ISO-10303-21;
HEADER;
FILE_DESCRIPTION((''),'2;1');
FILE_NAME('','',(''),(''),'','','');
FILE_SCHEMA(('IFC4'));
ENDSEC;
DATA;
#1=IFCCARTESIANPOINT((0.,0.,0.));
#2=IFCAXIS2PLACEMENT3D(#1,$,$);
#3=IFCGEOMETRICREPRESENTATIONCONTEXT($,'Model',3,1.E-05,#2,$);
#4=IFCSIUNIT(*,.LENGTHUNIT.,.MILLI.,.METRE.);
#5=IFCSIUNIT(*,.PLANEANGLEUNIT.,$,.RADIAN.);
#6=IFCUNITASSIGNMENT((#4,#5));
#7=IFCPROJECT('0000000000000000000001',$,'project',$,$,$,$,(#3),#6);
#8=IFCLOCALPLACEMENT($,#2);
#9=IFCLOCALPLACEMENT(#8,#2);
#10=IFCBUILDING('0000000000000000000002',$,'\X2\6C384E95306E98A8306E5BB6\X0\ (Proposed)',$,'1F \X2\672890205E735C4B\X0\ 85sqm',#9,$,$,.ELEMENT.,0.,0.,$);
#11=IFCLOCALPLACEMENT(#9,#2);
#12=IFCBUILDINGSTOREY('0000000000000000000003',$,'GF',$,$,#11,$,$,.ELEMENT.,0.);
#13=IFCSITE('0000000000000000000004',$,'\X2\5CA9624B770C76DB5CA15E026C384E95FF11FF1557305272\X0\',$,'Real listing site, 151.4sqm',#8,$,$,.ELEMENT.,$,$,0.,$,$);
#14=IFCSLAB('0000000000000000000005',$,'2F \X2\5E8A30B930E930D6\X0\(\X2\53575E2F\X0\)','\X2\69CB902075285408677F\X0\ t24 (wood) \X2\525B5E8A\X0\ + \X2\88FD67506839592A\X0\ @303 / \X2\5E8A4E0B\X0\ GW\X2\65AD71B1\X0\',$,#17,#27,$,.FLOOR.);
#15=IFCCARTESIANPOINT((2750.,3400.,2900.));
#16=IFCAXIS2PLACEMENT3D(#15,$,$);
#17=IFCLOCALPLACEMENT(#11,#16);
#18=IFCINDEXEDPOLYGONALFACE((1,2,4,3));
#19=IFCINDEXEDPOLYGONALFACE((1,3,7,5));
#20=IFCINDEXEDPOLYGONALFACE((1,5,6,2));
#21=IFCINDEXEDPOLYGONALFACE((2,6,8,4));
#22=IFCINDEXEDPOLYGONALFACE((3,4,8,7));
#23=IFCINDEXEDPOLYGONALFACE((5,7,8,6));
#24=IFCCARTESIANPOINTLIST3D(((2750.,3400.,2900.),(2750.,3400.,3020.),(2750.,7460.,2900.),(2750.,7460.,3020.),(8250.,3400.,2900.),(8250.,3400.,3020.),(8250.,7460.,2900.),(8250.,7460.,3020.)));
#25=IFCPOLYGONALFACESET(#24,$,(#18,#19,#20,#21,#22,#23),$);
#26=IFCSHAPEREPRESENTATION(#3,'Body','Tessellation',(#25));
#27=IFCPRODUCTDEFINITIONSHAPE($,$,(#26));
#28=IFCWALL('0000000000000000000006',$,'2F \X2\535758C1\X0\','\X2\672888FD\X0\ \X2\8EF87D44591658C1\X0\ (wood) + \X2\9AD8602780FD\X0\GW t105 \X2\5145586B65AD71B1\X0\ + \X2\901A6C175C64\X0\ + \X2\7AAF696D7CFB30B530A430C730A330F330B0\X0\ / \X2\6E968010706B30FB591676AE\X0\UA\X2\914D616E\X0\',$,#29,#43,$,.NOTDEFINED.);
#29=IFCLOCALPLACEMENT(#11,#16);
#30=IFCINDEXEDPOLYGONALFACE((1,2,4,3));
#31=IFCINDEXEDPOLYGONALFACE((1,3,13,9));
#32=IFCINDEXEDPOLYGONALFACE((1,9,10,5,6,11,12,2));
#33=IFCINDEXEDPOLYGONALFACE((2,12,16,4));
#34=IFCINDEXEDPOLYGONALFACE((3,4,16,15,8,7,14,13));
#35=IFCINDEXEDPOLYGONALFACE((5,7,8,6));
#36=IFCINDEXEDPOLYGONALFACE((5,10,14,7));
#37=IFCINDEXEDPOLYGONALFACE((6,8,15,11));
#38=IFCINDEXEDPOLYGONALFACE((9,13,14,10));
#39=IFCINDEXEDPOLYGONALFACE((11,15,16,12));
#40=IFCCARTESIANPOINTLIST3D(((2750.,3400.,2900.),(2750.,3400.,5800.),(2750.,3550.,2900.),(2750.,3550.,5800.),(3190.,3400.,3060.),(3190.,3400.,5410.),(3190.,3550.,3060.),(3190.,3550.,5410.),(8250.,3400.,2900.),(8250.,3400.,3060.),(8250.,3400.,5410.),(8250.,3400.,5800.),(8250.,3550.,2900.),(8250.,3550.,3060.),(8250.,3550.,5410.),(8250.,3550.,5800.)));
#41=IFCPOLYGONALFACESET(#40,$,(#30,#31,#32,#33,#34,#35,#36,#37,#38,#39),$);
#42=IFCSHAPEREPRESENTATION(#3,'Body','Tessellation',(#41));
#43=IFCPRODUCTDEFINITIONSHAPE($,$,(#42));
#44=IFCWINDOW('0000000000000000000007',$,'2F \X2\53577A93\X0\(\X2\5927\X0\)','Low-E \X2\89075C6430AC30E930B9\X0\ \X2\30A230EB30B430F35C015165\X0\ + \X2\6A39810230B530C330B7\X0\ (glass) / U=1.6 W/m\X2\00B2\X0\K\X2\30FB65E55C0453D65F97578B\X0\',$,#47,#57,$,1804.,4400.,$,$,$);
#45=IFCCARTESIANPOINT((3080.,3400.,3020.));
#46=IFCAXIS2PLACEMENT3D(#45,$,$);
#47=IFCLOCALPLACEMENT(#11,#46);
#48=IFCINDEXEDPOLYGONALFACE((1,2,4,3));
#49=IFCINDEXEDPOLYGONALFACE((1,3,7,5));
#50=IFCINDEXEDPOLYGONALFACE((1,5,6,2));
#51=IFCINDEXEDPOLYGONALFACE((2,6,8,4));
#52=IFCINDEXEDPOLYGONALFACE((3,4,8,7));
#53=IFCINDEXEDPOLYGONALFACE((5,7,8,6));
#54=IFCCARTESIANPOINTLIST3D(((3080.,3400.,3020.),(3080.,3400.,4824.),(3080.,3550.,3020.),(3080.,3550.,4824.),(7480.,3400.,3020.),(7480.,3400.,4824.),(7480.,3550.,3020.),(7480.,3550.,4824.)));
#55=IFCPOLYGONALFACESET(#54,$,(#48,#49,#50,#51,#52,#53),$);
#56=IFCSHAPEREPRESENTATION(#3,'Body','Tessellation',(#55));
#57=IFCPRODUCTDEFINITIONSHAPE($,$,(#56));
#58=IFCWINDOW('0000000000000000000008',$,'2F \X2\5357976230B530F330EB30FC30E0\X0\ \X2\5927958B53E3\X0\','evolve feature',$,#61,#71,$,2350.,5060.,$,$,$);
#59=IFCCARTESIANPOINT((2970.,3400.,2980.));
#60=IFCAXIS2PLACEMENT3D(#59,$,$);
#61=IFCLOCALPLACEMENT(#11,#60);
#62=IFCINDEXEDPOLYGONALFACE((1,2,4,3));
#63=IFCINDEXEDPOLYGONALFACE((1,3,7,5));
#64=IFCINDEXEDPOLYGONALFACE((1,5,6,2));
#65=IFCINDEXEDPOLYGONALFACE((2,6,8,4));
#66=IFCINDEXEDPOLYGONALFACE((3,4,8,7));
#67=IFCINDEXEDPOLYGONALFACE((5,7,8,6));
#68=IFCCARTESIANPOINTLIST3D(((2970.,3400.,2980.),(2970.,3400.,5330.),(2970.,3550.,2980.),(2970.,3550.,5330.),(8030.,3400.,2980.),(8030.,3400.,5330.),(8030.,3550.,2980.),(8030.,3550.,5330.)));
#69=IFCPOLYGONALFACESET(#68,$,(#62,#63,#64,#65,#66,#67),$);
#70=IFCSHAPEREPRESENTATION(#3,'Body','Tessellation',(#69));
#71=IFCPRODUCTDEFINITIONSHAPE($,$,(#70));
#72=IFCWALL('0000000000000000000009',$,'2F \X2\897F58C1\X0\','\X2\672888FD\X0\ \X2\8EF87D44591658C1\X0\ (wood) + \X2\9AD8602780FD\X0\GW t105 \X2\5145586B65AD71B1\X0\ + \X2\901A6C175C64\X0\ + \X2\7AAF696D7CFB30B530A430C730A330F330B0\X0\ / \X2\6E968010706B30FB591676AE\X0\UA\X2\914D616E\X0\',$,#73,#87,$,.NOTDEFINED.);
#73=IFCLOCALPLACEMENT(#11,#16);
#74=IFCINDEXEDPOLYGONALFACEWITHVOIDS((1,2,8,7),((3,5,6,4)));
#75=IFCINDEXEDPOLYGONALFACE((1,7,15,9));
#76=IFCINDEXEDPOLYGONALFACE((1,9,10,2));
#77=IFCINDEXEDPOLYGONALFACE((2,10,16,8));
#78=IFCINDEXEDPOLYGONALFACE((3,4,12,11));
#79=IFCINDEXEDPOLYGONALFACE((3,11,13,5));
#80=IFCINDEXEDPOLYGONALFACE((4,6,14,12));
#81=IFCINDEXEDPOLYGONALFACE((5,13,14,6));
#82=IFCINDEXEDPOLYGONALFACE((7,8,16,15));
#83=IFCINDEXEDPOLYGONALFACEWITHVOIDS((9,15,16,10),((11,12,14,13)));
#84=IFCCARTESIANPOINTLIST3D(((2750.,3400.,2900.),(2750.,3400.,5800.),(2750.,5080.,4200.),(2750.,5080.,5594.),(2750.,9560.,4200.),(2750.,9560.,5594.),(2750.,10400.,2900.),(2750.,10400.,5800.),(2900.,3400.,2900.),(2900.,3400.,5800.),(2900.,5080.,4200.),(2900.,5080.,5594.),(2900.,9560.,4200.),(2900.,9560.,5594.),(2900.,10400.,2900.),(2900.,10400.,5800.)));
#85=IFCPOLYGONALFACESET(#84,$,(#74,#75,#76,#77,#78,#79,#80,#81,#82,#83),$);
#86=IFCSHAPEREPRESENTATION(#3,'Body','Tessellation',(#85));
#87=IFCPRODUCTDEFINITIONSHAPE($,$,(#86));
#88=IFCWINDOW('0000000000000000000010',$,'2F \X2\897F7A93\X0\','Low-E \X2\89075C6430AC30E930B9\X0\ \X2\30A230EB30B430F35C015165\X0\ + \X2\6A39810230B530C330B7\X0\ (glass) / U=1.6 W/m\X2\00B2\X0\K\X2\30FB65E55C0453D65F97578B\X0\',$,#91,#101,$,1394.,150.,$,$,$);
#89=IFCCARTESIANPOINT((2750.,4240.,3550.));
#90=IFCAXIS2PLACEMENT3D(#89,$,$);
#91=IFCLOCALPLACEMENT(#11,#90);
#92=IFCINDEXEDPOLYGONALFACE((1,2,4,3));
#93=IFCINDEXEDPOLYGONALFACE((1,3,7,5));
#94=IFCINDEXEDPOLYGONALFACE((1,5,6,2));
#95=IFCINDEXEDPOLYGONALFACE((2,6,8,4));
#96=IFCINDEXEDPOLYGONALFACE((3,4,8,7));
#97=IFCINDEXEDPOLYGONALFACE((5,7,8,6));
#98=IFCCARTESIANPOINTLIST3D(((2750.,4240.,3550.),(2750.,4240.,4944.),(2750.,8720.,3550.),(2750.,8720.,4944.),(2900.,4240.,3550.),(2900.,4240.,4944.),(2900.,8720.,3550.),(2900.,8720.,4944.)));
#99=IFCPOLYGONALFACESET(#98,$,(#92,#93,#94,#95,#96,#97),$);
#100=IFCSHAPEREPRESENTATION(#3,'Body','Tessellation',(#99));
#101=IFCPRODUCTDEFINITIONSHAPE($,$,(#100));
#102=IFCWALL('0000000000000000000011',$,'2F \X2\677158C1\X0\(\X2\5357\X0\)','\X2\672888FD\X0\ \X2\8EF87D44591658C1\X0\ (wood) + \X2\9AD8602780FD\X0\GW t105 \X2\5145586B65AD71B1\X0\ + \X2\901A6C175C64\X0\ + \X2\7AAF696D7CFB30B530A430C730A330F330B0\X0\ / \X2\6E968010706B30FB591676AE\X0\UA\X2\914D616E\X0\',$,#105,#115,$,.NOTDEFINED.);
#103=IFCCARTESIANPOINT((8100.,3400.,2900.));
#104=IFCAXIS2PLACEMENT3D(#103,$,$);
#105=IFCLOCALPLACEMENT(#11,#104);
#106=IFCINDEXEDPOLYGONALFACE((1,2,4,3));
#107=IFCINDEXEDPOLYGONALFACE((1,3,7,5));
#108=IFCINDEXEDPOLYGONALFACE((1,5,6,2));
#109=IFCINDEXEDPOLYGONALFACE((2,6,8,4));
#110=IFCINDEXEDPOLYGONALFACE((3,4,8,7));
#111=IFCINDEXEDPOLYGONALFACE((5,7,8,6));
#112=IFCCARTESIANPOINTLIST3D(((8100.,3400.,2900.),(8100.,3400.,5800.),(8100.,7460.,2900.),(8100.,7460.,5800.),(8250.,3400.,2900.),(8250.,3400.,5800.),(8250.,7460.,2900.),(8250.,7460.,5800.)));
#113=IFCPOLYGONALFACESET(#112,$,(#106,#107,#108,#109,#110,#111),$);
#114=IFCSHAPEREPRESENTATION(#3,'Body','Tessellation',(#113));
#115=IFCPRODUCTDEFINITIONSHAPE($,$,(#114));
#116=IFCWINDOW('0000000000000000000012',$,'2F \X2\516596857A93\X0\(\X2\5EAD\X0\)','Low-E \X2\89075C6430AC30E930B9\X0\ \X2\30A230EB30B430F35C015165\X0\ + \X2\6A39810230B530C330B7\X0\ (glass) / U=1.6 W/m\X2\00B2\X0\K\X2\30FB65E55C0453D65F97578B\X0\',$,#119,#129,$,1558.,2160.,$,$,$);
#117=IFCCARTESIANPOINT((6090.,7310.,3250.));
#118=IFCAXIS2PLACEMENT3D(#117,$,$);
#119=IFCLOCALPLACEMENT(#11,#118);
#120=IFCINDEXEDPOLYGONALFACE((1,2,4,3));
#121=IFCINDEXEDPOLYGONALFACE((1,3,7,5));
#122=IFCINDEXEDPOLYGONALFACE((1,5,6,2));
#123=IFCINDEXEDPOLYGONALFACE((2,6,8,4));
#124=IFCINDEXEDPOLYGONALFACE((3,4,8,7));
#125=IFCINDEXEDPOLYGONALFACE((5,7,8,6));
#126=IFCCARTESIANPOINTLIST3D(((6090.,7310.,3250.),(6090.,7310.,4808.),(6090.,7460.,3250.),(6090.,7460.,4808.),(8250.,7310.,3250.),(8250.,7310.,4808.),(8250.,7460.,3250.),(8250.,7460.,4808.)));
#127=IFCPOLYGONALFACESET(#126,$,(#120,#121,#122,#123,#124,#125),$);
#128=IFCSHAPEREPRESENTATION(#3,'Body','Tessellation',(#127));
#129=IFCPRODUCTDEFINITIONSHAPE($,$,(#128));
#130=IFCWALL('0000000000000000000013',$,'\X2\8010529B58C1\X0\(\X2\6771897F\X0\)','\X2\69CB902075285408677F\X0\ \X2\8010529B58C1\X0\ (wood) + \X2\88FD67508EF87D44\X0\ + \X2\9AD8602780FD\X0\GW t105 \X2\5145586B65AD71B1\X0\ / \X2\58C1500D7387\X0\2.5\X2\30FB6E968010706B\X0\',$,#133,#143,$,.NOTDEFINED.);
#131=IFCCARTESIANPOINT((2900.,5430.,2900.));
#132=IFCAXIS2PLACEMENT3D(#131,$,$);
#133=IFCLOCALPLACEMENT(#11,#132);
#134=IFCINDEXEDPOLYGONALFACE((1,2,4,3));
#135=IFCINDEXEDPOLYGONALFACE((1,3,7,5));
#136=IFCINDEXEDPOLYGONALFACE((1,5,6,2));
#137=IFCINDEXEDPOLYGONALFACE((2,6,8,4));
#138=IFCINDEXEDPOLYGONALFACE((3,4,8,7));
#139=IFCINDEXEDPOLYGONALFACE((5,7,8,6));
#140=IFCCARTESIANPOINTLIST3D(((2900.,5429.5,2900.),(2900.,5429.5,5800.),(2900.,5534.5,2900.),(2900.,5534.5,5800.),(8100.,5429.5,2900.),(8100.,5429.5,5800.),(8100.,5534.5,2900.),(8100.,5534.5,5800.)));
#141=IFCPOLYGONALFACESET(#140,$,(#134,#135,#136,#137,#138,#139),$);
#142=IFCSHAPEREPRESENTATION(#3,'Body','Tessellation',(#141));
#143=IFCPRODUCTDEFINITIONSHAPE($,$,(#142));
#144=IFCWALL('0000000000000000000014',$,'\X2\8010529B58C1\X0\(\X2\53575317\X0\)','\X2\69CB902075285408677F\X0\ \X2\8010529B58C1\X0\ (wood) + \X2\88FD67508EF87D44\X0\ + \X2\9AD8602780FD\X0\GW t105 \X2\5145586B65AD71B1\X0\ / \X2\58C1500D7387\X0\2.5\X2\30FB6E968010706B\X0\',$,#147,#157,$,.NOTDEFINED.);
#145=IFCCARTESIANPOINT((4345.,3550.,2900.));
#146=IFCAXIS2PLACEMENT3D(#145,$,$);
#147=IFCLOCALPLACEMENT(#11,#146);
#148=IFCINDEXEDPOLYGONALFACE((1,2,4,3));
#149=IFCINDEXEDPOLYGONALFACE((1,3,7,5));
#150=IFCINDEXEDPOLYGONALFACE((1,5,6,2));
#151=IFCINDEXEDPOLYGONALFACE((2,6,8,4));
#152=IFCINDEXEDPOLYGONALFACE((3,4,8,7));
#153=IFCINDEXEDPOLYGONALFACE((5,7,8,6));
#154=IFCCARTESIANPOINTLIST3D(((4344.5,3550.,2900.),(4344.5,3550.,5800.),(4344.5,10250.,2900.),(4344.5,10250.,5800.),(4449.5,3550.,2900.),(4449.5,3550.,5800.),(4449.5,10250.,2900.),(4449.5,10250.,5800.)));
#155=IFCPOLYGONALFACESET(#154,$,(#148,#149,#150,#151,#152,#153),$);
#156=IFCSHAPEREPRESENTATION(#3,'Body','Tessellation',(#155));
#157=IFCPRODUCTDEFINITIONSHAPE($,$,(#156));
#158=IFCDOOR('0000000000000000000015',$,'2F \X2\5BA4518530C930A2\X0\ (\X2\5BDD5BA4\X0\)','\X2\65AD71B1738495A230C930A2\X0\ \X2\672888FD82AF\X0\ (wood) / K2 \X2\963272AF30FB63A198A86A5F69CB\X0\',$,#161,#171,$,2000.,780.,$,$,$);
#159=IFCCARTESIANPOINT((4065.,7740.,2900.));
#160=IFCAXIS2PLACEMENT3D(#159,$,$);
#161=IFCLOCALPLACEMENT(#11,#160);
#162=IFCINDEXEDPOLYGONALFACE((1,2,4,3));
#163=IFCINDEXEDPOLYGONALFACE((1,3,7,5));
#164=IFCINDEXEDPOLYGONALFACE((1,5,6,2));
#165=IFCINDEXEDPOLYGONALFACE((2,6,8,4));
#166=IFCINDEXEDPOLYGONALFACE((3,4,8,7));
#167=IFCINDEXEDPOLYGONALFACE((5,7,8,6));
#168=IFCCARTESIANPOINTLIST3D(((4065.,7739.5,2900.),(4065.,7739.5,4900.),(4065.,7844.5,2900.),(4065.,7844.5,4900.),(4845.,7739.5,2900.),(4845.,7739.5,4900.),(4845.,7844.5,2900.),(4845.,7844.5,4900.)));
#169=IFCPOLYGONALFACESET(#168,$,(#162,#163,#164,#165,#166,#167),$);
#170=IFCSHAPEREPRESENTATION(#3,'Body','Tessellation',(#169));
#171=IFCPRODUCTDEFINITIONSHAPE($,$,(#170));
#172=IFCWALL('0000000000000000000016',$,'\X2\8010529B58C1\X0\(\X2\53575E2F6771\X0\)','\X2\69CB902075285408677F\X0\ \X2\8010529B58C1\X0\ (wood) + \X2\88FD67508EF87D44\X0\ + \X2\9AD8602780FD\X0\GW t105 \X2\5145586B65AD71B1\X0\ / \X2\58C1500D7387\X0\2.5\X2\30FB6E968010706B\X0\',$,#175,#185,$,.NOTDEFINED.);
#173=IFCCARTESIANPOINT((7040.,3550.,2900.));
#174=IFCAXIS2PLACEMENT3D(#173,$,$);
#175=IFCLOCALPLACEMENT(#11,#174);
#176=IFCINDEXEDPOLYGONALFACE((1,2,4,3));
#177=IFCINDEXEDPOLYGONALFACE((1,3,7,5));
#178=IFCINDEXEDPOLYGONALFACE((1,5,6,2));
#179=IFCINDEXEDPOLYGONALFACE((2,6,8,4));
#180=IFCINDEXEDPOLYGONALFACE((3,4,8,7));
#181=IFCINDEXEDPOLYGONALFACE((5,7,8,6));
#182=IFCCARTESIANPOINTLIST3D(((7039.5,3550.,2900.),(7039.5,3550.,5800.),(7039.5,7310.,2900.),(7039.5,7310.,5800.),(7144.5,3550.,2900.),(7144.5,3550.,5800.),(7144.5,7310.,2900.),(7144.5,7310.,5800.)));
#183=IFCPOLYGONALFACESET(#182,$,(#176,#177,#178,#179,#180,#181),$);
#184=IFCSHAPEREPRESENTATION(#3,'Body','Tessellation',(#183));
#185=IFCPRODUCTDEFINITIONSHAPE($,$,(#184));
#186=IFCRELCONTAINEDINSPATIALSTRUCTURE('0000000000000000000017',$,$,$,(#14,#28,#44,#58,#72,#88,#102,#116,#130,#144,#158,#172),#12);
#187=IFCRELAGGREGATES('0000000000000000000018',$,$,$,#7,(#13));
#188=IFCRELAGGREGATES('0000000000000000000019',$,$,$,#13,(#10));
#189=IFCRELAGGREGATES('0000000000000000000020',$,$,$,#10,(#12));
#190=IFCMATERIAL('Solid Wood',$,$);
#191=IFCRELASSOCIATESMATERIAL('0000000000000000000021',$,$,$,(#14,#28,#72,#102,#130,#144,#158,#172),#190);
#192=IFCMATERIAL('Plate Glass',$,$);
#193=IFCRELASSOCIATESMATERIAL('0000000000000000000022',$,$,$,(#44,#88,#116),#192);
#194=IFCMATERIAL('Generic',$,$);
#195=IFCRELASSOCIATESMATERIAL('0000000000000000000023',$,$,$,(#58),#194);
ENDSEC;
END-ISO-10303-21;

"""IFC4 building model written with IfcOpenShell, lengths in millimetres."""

from ifc_helpers import new_model, si_unit, frame, frame_2d, origin, place, context, project, spatial, rectangle, extrude, material, element, fill, save


model = new_model("IFC4")

# Units and contexts
model_context = context("Model", 3, precision=1e-05, world=origin())
ifc_project = project(units=[si_unit("LENGTHUNIT", "METRE", prefix="MILLI"), si_unit("PLANEANGLEUNIT", "RADIAN")], contexts=[model_context])

# Site, building, storey
site_placement = place(None, origin())
site = spatial("IfcSite", under=ifc_project, at=site_placement, Name="岩手県盛岡市永井１５地割", ObjectType="Real listing site, 151.4sqm", CompositionType="ELEMENT", RefElevation=0.0)
building_placement = place(site_placement, origin())
building = spatial("IfcBuilding", under=site, at=building_placement, Name="永井の風の家 (Proposed)", ObjectType="1F 木造平屋 85sqm", CompositionType="ELEMENT", ElevationOfRefHeight=0.0, ElevationOfTerrain=0.0)
storey_placement = place(building_placement, origin())
storey = spatial("IfcBuildingStorey", under=building, at=storey_placement, Name="GF", CompositionType="ELEMENT", Elevation=0.0)

# Slab
ifc_material_1 = material(Name="Solid Wood")
slab_placement = place(storey_placement, frame((2750.0, 3400.0, 2900.0)))
element("IfcSlab", 1, at=slab_placement, inside=storey, material=ifc_material_1, Name="2F 床スラブ(南帯)", Description="構造用合板 t24 (wood) 剛床 + 製材根太 @303 / 床下 GW断熱", PredefinedType="FLOOR", context=model_context, shape_type="SweptSolid", body=[
    extrude(rectangle(XDim=5500.0, YDim=4060.0, at=frame_2d((2750.0, 2030.0))), frame((2750.0, 3400.0, 2900.0)), (0.0, 0.0, 1.0), 120.0),
])

# Wall, openings, windows
wall_1_placement = place(storey_placement, frame((2750.0, 3400.0, 2900.0)))
wall_1 = element("IfcWall", 2, at=wall_1_placement, inside=storey, material=ifc_material_1, Name="2F 南壁", Description="木製 軸組外壁 (wood) + 高性能GW t105 充填断熱 + 通気層 + 窯業系サイディング / 準耐火・外皮UA配慮", PredefinedType="NOTDEFINED", context=model_context, shape_type="SweptSolid", body=[
    extrude(rectangle(XDim=5500.0, YDim=150.0, at=frame_2d((2750.0, 75.0))), frame((2750.0, 3400.0, 2900.0)), (0.0, 0.0, 1.0), 2900.0),
])
opening_1_placement = place(storey_placement, frame((3080.0, 3400.0, 3020.0)))
opening_1 = element("IfcOpeningElement", 3, at=opening_1_placement, cuts=wall_1, PredefinedType="NOTDEFINED", context=model_context, shape_type="SweptSolid", body=[
    extrude(rectangle(XDim=4400.0, YDim=150.0, at=frame_2d((2200.0, 75.0))), frame((3080.0, 3400.0, 3020.0)), (0.0, 0.0, 1.0), 1804.0),
])
opening_2_placement = place(storey_placement, frame((2970.0, 3400.0, 2980.0)))
opening_2 = element("IfcOpeningElement", 4, at=opening_2_placement, cuts=wall_1, PredefinedType="NOTDEFINED", context=model_context, shape_type="SweptSolid", body=[
    extrude(rectangle(XDim=5060.0, YDim=150.0, at=frame_2d((2530.0, 75.0))), frame((2970.0, 3400.0, 2980.0)), (0.0, 0.0, 1.0), 2350.0),
])
ifc_material_2 = material(Name="Plate Glass")
window_1_placement = place(storey_placement, frame((3080.0, 3400.0, 3020.0)))
window_1 = element("IfcWindow", 5, at=window_1_placement, inside=storey, material=ifc_material_2, Name="2F 南窓(大)", Description="Low-E 複層ガラス アルゴン封入 + 樹脂サッシ (glass) / U=1.6 W/m²K・日射取得型", OverallHeight=1804.0, OverallWidth=4400.0, context=model_context, shape_type="SweptSolid", body=[
    extrude(rectangle(XDim=4400.0, YDim=150.0, at=frame_2d((2200.0, 75.0))), frame((3080.0, 3400.0, 3020.0)), (0.0, 0.0, 1.0), 1804.0),
])
fill(opening_1, window_1)
ifc_material_3 = material(Name="Generic")
window_2_placement = place(storey_placement, frame((2970.0, 3400.0, 2980.0)))
window_2 = element("IfcWindow", 6, at=window_2_placement, inside=storey, material=ifc_material_3, Name="2F 南面サンルーム 大開口", Description="evolve feature", OverallHeight=2350.0, OverallWidth=5060.0, context=model_context, shape_type="SweptSolid", body=[
    extrude(rectangle(XDim=5060.0, YDim=150.0, at=frame_2d((2530.0, 75.0))), frame((2970.0, 3400.0, 2980.0)), (0.0, 0.0, 1.0), 2350.0),
])
fill(opening_2, window_2)

# Walls, openings, windows
wall_2_placement = place(storey_placement, frame((2750.0, 3400.0, 2900.0)))
wall_2 = element("IfcWall", 7, at=wall_2_placement, inside=storey, material=ifc_material_1, Name="2F 西壁", Description="木製 軸組外壁 (wood) + 高性能GW t105 充填断熱 + 通気層 + 窯業系サイディング / 準耐火・外皮UA配慮", PredefinedType="NOTDEFINED", context=model_context, shape_type="SweptSolid", body=[
    extrude(rectangle(XDim=150.0, YDim=7000.0, at=frame_2d((75.0, 3500.0))), frame((2750.0, 3400.0, 2900.0)), (0.0, 0.0, 1.0), 2900.0),
])
opening_3_placement = place(storey_placement, frame((2750.0, 4240.0, 3550.0)))
opening_3 = element("IfcOpeningElement", 8, at=opening_3_placement, cuts=wall_2, PredefinedType="NOTDEFINED", context=model_context, shape_type="SweptSolid", body=[
    extrude(rectangle(XDim=150.0, YDim=4480.0, at=frame_2d((75.0, 2240.0))), frame((2750.0, 4240.0, 3550.0)), (0.0, 0.0, 1.0), 1394.0),
])
window_3_placement = place(storey_placement, frame((2750.0, 4240.0, 3550.0)))
window_3 = element("IfcWindow", 9, at=window_3_placement, inside=storey, material=ifc_material_2, Name="2F 西窓", Description="Low-E 複層ガラス アルゴン封入 + 樹脂サッシ (glass) / U=1.6 W/m²K・日射取得型", OverallHeight=1394.0, OverallWidth=150.0, context=model_context, shape_type="SweptSolid", body=[
    extrude(rectangle(XDim=150.0, YDim=4480.0, at=frame_2d((75.0, 2240.0))), frame((2750.0, 4240.0, 3550.0)), (0.0, 0.0, 1.0), 1394.0),
])
fill(opening_3, window_3)
wall_3_placement = place(storey_placement, frame((8100.0, 3400.0, 2900.0)))
wall_3 = element("IfcWall", 10, at=wall_3_placement, inside=storey, material=ifc_material_1, Name="2F 東壁(南)", Description="木製 軸組外壁 (wood) + 高性能GW t105 充填断熱 + 通気層 + 窯業系サイディング / 準耐火・外皮UA配慮", PredefinedType="NOTDEFINED", context=model_context, shape_type="SweptSolid", body=[
    extrude(rectangle(XDim=150.0, YDim=4060.0, at=frame_2d((75.0, 2030.0))), frame((8100.0, 3400.0, 2900.0)), (0.0, 0.0, 1.0), 2900.0),
])
opening_4_placement = place(storey_placement, frame((6090.0, 7310.0, 3250.0)))
opening_4 = element("IfcOpeningElement", 11, at=opening_4_placement, cuts=wall_3, PredefinedType="NOTDEFINED", context=model_context, shape_type="SweptSolid", body=[
    extrude(rectangle(XDim=2160.0, YDim=150.0, at=frame_2d((1080.0, 75.0))), frame((6090.0, 7310.0, 3250.0)), (0.0, 0.0, 1.0), 1558.0),
])
window_4_placement = place(storey_placement, frame((6090.0, 7310.0, 3250.0)))
window_4 = element("IfcWindow", 12, at=window_4_placement, inside=storey, material=ifc_material_2, Name="2F 入隅窓(庭)", Description="Low-E 複層ガラス アルゴン封入 + 樹脂サッシ (glass) / U=1.6 W/m²K・日射取得型", OverallHeight=1558.0, OverallWidth=2160.0, context=model_context, shape_type="SweptSolid", body=[
    extrude(rectangle(XDim=2160.0, YDim=150.0, at=frame_2d((1080.0, 75.0))), frame((6090.0, 7310.0, 3250.0)), (0.0, 0.0, 1.0), 1558.0),
])
fill(opening_4, window_4)

# Wall
wall_4_placement = place(storey_placement, frame((2900.0, 5430.0, 2900.0)))
element("IfcWall", 13, at=wall_4_placement, inside=storey, material=ifc_material_1, Name="耐力壁(東西)", Description="構造用合板 耐力壁 (wood) + 製材軸組 + 高性能GW t105 充填断熱 / 壁倍率2.5・準耐火", PredefinedType="NOTDEFINED", context=model_context, shape_type="SweptSolid", body=[
    extrude(rectangle(XDim=5200.0, YDim=105.0, at=frame_2d((2600.0, 52.0))), frame((2900.0, 5430.0, 2900.0)), (0.0, 0.0, 1.0), 2900.0),
])

# Wall, opening, door
wall_5_placement = place(storey_placement, frame((4345.0, 3550.0, 2900.0)))
wall_5 = element("IfcWall", 14, at=wall_5_placement, inside=storey, material=ifc_material_1, Name="耐力壁(南北)", Description="構造用合板 耐力壁 (wood) + 製材軸組 + 高性能GW t105 充填断熱 / 壁倍率2.5・準耐火", PredefinedType="NOTDEFINED", context=model_context, shape_type="SweptSolid", body=[
    extrude(rectangle(XDim=105.0, YDim=6700.0, at=frame_2d((52.0, 3350.0))), frame((4345.0, 3550.0, 2900.0)), (0.0, 0.0, 1.0), 2900.0),
])
opening_5_placement = place(storey_placement, frame((4065.0, 7740.0, 2900.0)))
opening_5 = element("IfcOpeningElement", 15, at=opening_5_placement, cuts=wall_5, PredefinedType="NOTDEFINED", context=model_context, shape_type="SweptSolid", body=[
    extrude(rectangle(XDim=780.0, YDim=105.0, at=frame_2d((390.0, 52.0))), frame((4065.0, 7740.0, 2900.0)), (0.0, 0.0, 1.0), 2000.0),
])
door_placement = place(storey_placement, frame((4065.0, 7740.0, 2900.0)))
door = element("IfcDoor", 16, at=door_placement, inside=storey, material=ifc_material_1, Name="2F 室内ドア (寝室)", Description="断熱玄関ドア 木製芯 (wood) / K2 防犯・採風機構", OverallHeight=2000.0, OverallWidth=780.0, context=model_context, shape_type="SweptSolid", body=[
    extrude(rectangle(XDim=780.0, YDim=105.0, at=frame_2d((390.0, 52.0))), frame((4065.0, 7740.0, 2900.0)), (0.0, 0.0, 1.0), 2000.0),
])
fill(opening_5, door)

# Wall
wall_6_placement = place(storey_placement, frame((7040.0, 3550.0, 2900.0)))
element("IfcWall", 17, at=wall_6_placement, inside=storey, material=ifc_material_1, Name="耐力壁(南帯東)", Description="構造用合板 耐力壁 (wood) + 製材軸組 + 高性能GW t105 充填断熱 / 壁倍率2.5・準耐火", PredefinedType="NOTDEFINED", context=model_context, shape_type="SweptSolid", body=[
    extrude(rectangle(XDim=105.0, YDim=3760.0, at=frame_2d((52.0, 1880.0))), frame((7040.0, 3550.0, 2900.0)), (0.0, 0.0, 1.0), 2900.0),
])

save(model, "model.ifc")
